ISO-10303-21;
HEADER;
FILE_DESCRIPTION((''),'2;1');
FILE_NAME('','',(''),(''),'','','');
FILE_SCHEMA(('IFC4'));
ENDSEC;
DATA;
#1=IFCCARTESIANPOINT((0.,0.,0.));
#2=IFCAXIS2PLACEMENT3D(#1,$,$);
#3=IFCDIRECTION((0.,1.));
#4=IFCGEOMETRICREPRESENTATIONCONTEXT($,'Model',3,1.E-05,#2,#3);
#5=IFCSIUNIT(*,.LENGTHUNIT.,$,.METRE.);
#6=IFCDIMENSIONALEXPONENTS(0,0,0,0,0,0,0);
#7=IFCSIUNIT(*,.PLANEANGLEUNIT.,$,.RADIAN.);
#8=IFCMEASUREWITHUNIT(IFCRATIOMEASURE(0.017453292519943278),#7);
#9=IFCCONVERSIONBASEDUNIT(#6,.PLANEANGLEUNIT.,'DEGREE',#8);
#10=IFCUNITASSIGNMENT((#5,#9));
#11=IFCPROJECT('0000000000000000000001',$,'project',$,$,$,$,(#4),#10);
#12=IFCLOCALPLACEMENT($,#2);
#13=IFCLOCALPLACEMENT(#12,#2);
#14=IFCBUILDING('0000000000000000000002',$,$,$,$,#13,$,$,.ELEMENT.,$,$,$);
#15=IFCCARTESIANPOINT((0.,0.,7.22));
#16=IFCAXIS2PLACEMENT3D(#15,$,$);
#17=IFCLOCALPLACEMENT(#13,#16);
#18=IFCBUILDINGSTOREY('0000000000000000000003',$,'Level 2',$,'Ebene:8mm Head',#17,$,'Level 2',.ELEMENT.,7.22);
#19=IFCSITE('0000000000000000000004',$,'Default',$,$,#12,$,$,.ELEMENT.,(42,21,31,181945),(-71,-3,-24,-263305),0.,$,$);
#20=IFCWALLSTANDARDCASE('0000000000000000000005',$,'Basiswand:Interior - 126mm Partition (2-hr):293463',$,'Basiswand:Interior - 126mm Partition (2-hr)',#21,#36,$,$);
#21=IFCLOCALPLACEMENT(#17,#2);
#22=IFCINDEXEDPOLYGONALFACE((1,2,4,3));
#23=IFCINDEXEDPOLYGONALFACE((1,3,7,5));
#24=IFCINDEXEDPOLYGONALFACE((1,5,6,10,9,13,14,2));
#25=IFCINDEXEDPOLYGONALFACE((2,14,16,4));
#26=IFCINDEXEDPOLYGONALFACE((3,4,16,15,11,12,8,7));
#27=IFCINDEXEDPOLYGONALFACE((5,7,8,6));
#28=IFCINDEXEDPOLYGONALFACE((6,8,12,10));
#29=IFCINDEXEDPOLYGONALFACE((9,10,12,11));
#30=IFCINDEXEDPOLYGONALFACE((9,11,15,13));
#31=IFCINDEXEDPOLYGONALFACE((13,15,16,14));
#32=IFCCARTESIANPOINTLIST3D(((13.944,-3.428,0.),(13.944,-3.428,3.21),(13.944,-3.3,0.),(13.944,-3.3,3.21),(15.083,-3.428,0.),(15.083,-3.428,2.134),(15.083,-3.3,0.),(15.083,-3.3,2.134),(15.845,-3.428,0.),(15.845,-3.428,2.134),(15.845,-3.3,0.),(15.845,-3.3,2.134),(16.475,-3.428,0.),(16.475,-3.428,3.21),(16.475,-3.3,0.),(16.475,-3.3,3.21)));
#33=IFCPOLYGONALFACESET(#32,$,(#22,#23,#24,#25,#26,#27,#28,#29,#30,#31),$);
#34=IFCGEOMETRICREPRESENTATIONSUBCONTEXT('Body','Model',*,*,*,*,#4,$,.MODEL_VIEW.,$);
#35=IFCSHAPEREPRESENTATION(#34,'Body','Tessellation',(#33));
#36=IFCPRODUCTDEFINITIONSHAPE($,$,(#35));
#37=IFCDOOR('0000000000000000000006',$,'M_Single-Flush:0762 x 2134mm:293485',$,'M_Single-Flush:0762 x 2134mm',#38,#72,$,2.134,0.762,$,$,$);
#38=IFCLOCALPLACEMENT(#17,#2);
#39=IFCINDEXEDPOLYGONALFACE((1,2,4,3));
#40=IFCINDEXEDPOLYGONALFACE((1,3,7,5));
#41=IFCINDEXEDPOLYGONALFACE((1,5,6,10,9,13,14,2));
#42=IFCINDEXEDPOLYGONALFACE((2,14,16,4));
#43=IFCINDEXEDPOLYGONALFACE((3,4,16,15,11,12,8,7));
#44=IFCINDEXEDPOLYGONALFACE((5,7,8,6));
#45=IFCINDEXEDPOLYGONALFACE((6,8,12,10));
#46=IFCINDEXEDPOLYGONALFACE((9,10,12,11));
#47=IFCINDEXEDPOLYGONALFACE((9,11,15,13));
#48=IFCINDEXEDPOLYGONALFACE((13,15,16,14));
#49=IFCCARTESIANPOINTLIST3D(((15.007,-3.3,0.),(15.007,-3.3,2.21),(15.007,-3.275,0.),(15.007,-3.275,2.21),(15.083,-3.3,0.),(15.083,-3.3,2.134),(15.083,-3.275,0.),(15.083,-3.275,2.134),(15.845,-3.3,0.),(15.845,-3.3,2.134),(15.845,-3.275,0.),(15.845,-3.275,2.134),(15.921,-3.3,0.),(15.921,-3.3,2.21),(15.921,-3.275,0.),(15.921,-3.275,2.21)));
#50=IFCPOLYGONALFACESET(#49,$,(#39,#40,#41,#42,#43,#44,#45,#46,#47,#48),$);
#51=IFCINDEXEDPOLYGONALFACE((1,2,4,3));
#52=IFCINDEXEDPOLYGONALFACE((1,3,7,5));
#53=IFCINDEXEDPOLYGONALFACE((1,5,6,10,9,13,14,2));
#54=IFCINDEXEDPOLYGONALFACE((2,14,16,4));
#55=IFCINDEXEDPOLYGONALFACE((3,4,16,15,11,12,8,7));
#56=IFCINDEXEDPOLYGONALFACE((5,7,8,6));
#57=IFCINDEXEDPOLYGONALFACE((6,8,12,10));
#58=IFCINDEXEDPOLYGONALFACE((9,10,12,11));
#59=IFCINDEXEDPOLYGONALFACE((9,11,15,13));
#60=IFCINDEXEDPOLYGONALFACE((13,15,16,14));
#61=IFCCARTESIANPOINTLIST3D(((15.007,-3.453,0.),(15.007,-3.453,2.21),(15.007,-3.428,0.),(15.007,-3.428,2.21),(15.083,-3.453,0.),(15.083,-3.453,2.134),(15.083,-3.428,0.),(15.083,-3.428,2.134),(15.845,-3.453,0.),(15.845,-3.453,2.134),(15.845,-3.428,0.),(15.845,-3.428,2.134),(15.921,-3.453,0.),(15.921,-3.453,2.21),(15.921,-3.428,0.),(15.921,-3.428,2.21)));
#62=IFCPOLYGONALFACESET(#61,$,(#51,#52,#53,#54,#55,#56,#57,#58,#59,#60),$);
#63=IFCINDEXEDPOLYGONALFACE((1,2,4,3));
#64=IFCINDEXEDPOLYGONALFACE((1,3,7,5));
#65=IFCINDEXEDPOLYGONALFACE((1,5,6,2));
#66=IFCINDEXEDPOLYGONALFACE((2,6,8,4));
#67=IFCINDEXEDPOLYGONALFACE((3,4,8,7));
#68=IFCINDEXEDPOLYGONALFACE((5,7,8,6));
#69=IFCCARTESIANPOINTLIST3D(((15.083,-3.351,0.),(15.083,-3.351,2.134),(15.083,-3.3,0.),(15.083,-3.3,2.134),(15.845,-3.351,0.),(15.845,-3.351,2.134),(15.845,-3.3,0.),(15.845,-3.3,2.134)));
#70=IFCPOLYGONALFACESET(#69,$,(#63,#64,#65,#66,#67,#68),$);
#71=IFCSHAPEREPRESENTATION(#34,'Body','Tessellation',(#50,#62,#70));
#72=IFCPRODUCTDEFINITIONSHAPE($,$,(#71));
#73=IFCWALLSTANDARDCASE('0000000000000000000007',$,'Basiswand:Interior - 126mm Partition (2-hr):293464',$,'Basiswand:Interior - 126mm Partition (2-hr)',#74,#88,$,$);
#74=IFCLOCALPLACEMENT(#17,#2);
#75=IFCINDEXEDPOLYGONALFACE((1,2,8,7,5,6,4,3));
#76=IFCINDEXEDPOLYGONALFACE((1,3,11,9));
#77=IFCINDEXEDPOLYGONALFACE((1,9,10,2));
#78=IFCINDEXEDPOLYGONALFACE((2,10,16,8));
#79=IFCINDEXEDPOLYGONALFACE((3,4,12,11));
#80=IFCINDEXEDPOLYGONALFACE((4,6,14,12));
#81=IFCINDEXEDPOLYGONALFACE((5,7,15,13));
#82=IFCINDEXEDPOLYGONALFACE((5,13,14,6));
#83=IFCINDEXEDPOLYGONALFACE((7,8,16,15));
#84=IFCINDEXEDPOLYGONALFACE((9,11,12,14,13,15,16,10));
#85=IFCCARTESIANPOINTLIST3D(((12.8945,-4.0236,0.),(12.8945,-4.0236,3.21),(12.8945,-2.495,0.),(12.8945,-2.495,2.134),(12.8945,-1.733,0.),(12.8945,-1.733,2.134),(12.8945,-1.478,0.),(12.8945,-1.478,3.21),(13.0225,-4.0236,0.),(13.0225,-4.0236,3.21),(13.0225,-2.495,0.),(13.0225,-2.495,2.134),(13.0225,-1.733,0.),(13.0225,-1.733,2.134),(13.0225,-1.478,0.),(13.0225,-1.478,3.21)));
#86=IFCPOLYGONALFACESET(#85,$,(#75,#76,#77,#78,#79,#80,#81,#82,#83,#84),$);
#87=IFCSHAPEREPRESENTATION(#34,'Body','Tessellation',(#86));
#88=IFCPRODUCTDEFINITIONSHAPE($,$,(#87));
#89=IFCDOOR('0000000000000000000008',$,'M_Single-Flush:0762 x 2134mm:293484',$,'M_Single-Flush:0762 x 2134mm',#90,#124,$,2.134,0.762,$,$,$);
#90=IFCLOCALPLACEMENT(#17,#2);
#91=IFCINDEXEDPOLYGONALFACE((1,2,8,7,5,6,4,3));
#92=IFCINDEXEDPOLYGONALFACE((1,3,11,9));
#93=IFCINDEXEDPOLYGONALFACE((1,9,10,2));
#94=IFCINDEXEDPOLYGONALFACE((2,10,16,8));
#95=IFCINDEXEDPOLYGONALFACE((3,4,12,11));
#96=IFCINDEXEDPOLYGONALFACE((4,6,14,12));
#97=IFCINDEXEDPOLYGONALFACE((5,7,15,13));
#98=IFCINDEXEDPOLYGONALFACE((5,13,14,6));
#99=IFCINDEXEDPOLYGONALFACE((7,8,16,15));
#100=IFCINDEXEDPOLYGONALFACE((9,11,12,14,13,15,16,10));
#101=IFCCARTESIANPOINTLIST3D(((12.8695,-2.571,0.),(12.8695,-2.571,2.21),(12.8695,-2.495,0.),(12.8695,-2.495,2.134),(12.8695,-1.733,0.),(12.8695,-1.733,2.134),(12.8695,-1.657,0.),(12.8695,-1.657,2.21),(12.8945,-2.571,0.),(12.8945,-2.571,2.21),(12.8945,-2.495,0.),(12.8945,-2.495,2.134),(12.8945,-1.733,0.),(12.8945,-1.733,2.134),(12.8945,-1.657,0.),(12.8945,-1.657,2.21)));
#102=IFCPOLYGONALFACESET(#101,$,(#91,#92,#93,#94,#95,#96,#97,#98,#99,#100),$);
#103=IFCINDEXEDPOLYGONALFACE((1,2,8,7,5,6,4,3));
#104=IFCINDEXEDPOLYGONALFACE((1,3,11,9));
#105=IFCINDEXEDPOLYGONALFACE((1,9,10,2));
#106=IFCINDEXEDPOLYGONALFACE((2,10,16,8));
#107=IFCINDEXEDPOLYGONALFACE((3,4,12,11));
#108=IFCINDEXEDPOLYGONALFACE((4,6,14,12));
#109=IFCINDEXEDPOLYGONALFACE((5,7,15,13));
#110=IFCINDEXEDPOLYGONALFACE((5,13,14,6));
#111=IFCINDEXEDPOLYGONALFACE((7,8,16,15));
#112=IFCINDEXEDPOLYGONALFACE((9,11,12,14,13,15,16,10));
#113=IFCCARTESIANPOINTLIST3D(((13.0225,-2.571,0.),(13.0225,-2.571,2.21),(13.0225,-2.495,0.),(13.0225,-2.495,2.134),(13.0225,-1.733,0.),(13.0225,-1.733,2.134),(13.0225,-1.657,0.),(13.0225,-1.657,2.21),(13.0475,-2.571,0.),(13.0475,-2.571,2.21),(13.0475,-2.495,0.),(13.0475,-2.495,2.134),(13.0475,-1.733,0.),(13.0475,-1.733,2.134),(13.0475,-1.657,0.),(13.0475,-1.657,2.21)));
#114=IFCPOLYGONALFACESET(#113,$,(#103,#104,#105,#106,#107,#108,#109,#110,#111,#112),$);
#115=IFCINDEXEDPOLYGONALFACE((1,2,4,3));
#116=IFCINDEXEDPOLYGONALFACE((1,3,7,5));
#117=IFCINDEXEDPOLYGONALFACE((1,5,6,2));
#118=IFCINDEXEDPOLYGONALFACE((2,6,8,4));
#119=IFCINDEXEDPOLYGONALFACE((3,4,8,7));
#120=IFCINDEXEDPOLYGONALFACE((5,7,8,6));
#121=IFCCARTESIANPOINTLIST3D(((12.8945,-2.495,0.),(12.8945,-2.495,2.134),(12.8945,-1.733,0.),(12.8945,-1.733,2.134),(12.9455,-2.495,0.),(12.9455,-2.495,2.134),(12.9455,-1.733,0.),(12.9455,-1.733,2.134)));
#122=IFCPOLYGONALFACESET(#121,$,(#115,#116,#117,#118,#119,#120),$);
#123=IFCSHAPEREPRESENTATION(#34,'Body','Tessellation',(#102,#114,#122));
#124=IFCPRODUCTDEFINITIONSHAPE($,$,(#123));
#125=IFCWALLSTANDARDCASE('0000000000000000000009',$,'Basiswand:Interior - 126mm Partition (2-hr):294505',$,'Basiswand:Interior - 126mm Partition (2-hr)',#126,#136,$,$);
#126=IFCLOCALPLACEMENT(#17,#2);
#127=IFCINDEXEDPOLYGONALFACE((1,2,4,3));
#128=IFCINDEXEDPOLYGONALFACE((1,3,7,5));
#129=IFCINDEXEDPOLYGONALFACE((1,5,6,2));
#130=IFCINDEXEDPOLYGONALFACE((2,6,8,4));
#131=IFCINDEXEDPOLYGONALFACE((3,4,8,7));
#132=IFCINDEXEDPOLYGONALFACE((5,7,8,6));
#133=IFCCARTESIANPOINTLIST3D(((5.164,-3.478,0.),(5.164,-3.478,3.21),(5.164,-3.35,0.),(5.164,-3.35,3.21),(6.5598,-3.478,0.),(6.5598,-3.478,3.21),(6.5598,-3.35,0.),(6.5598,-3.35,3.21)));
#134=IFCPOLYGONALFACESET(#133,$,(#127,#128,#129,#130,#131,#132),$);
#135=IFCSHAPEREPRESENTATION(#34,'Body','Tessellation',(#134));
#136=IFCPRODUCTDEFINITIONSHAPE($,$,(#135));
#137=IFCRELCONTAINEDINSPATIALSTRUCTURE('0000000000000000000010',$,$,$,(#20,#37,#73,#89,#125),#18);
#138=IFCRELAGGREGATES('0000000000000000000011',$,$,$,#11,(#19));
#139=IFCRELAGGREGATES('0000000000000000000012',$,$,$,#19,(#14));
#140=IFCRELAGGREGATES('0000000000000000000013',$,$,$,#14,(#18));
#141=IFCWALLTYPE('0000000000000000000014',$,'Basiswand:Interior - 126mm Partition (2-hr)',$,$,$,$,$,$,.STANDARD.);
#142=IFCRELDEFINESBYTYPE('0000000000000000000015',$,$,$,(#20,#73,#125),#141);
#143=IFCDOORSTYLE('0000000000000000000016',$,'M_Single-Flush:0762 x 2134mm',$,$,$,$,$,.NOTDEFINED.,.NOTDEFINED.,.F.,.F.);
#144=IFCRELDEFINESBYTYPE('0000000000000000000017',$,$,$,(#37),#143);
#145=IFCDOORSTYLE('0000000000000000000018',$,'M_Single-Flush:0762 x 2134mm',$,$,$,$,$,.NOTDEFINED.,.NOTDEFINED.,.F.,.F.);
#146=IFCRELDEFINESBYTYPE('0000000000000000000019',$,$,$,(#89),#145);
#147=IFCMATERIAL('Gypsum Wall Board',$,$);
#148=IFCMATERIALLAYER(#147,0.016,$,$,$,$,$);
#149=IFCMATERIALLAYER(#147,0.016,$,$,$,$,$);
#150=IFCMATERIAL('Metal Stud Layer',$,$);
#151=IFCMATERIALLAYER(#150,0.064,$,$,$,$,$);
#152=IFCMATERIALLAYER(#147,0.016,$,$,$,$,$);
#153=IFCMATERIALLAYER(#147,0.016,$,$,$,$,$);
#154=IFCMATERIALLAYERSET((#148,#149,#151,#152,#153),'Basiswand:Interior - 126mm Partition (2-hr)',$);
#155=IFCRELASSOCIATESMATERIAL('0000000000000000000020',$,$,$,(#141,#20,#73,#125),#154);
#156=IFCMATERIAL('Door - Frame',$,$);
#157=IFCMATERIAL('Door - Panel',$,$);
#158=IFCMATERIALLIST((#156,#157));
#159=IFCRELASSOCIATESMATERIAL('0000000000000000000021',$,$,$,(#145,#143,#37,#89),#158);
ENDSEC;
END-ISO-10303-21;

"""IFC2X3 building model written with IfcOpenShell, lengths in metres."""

from ifc_helpers import new_model, entity, si_unit, converted_unit, direction, frame, frame_2d, origin, place, context, subcontext, project, spatial, polyline, rectangle, outline, extrude, clip, bounded_halfspace, source, transform, mapped, material, material_list, layer, layer_set, layer_usage, type_object, type_shapes, element, fill, save


model = new_model("IFC2X3")

# Units and contexts
model_context = context("Model", 3, precision=1e-05, world=origin(), true_north=direction((0.0, 1.0)))
body_context = subcontext(model_context, "Body", "Model", "MODEL_VIEW")
ifc_project = project(units=[si_unit("LENGTHUNIT", "METRE"), converted_unit("PLANEANGLEUNIT", "DEGREE", entity("IfcRatioMeasure", 0.017453292519943278), si_unit("PLANEANGLEUNIT", "RADIAN"), dimensions=[0, 0, 0, 0, 0, 0, 0])], contexts=[model_context])

# Site, building, storey
site_placement = place(None, origin())
site = spatial("IfcSite", under=ifc_project, at=site_placement, Name="Default", CompositionType="ELEMENT", RefLatitude=(42, 21, 31, 181945), RefLongitude=(-71, -3, -24, -263305), RefElevation=0.0)
building_placement = place(site_placement, origin())
building = spatial("IfcBuilding", under=site, at=building_placement, CompositionType="ELEMENT")
storey_placement = place(building_placement, frame((0.0, 0.0, 7.22)))
storey = spatial("IfcBuildingStorey", under=building, at=storey_placement, Name="Level 2", ObjectType="Ebene:8mm Head", LongName="Level 2", CompositionType="ELEMENT", Elevation=7.22)

# Shared definitions
ifc_material_1 = material(Name="Door - Frame")
ifc_material_2 = material(Name="Door - Panel")
ifc_material_list = material_list([ifc_material_1, ifc_material_2])

# Shared definitions
ifc_material_3 = material(Name="Gypsum Wall Board")
ifc_layer_1 = layer(ifc_material_3, 0.016)
ifc_layer_2 = layer(ifc_material_3, 0.016)
ifc_material_4 = material(Name="Metal Stud Layer")
ifc_layer_3 = layer(ifc_material_4, 0.064)
ifc_layer_4 = layer(ifc_material_3, 0.016)
ifc_layer_5 = layer(ifc_material_3, 0.016)
ifc_layer_set_1 = layer_set([ifc_layer_1, ifc_layer_2, ifc_layer_3, ifc_layer_4, ifc_layer_5], Name="Basiswand:Interior - 126mm Partition (2-hr)")
ifc_layer_usage_1 = layer_usage(ifc_layer_set_1, "AXIS2", "NEGATIVE", 0.064)
wall_type_1 = type_object("IfcWallType", Name="Basiswand:Interior - 126mm Partition (2-hr)", PredefinedType="STANDARD", material=ifc_layer_set_1)

# Walls, openings, doors
door_style_1 = type_object("IfcDoorStyle", Name="M_Single-Flush:0762 x 2134mm", ConstructionType="NOTDEFINED", OperationType="NOTDEFINED", ParameterTakesPrecedence=False, Sizeable=False, material=ifc_material_list)
shared_shape_1 = source(origin(), body_context, "Body", "SweptSolid", [
    extrude(outline(polyline([(-0.457, -1.124), (0.457, -1.124), (0.457, 1.086), (0.381, 1.086), (0.381, -1.048), (-0.381, -1.048), (-0.381, 1.086), (-0.457, 1.086), (-0.457, -1.124)])), frame((0.381, 0.128, 1.086), z_axis=(0.0, 1.0, 0.0), x_axis=(1.0, 0.0, 0.0)), (0.0, 0.0, 1.0), 0.025),
    extrude(outline(polyline([(-1.124, -0.457), (1.086, -0.457), (1.086, -0.381), (-1.048, -0.381), (-1.048, 0.381), (1.086, 0.381), (1.086, 0.457), (-1.124, 0.457), (-1.124, -0.457)])), frame((0.381, -0.025, 1.086), z_axis=(0.0, 1.0, 0.0), x_axis=(0.0, 0.0, -1.0)), (0.0, 0.0, 1.0), 0.025),
    extrude(rectangle(XDim=0.051, YDim=0.762, at=frame_2d((0.0, 0.0), x_axis=(1.0, 0.0))), frame((0.381, 0.1025, 0.0), z_axis=(0.0, 0.0, 1.0), x_axis=(0.0, 1.0, 0.0)), (0.0, 0.0, 1.0), 2.134),
])
type_shapes(door_style_1, [shared_shape_1])
door_style_2 = type_object("IfcDoorStyle", Name="M_Single-Flush:0762 x 2134mm", ConstructionType="NOTDEFINED", OperationType="NOTDEFINED", ParameterTakesPrecedence=False, Sizeable=False, material=ifc_material_list)
shared_shape_2 = source(origin(), body_context, "Body", "SweptSolid", [
    extrude(outline(polyline([(-0.457, -1.124), (0.457, -1.124), (0.457, 1.086), (0.381, 1.086), (0.381, -1.048), (-0.381, -1.048), (-0.381, 1.086), (-0.457, 1.086), (-0.457, -1.124)])), frame((0.381, 0.153, 1.086), z_axis=(0.0, -1.0, 0.0), x_axis=(-1.0, 0.0, 0.0)), (0.0, 0.0, 1.0), 0.025),
    extrude(outline(polyline([(-1.124, -0.457), (1.086, -0.457), (1.086, -0.381), (-1.048, -0.381), (-1.048, 0.381), (1.086, 0.381), (1.086, 0.457), (-1.124, 0.457), (-1.124, -0.457)])), frame((0.381, 0.0, 1.086), z_axis=(0.0, -1.0, 0.0), x_axis=(0.0, 0.0, -1.0)), (0.0, 0.0, 1.0), 0.025),
    extrude(rectangle(XDim=0.762, YDim=0.051, at=frame_2d((0.0, 0.0), x_axis=(1.0, 0.0))), frame((0.381, 0.1025, 0.0)), (0.0, 0.0, 1.0), 2.134),
])
type_shapes(door_style_2, [shared_shape_2])
wall_1_placement = place(storey_placement, frame((13.944, -3.364, 0.0)))
wall_1 = element("IfcWallStandardCase", 1, at=wall_1_placement, inside=storey, type_object=wall_type_1, material=ifc_layer_usage_1, Name="Basiswand:Interior - 126mm Partition (2-hr):293463", ObjectType="Basiswand:Interior - 126mm Partition (2-hr)", context=body_context, shape_type="Clipping", body=[
    clip(extrude(rectangle(XDim=2.531, YDim=0.128, at=frame_2d((1.2655, 0.0), x_axis=(-1.0, 0.0))), origin(), (0.0, 0.0, 1.0), 3.21), bounded_halfspace(frame((0.0, -0.064, 3.21), z_axis=(0.0, 0.0, -1.0), x_axis=(0.0, 1.0, 0.0)), True, frame((0.0, -0.064, 3.21)), polyline([(0.0, 0.0), (2.531, 0.0), (2.531, 0.128), (0.784, 0.128), (0.656, 0.128), (0.0, 0.128), (0.0, 0.0)]))),
])
opening_1_placement = place(wall_1_placement, frame((1.139, -0.064, 0.0)))
opening_1 = element("IfcOpeningElement", 2, at=opening_1_placement, cuts=wall_1, ObjectType="Opening", context=body_context, shape_type="SweptSolid", body=[
    extrude(rectangle(XDim=0.762, YDim=2.134, at=frame_2d((1.067, 0.381), x_axis=(0.0, -1.0))), frame((0.0, 0.0, 0.0), z_axis=(0.0, 1.0, 0.0), x_axis=(0.0, 0.0, 1.0)), (0.0, 0.0, 1.0), 0.128),
])
door_1_placement = place(opening_1_placement, origin())
door_1 = element("IfcDoor", 3, at=door_1_placement, inside=storey, type_object=door_style_2, material=ifc_material_list, Name="M_Single-Flush:0762 x 2134mm:293485", ObjectType="M_Single-Flush:0762 x 2134mm", OverallHeight=2.134, OverallWidth=0.762, context=body_context, shape_type="MappedRepresentation", body=[
    mapped(shared_shape_2, transform((0.0, 0.0, 0.0), scale=1.0)),
])
fill(opening_1, door_1)
wall_2_placement = place(storey_placement, frame((12.9585, -4.0236, 0.0), z_axis=(0.0, 0.0, 1.0), x_axis=(0.0, 1.0, 0.0)))
wall_2 = element("IfcWallStandardCase", 4, at=wall_2_placement, inside=storey, type_object=wall_type_1, material=ifc_layer_usage_1, Name="Basiswand:Interior - 126mm Partition (2-hr):293464", ObjectType="Basiswand:Interior - 126mm Partition (2-hr)", context=body_context, shape_type="Clipping", body=[
    clip(extrude(rectangle(XDim=2.5456, YDim=0.128, at=frame_2d((1.2728, 0.0), x_axis=(-1.0, 0.0))), origin(), (0.0, 0.0, 1.0), 3.21), bounded_halfspace(frame((0.0, -0.064, 3.21), z_axis=(0.0, 0.0, -1.0), x_axis=(1.0, 0.0, 0.0)), True, frame((0.0, -0.064, 3.21)), polyline([(0.0, 0.0), (2.5456, 0.0), (2.5456, 0.128), (0.6736, 0.128), (0.5456, 0.128), (0.0, 0.128), (0.0, 0.0)]))),
])
opening_2_placement = place(wall_2_placement, frame((1.5286, -0.064, 0.0)))
opening_2 = element("IfcOpeningElement", 5, at=opening_2_placement, cuts=wall_2, ObjectType="Opening", context=body_context, shape_type="SweptSolid", body=[
    extrude(rectangle(XDim=0.762, YDim=2.134, at=frame_2d((1.067, 0.381), x_axis=(0.0, 1.0))), frame((0.0, 0.0, 0.0), z_axis=(0.0, 1.0, 0.0), x_axis=(0.0, 0.0, 1.0)), (0.0, 0.0, 1.0), 0.128),
])
door_2_placement = place(opening_2_placement, origin())
door_2 = element("IfcDoor", 6, at=door_2_placement, inside=storey, type_object=door_style_1, material=ifc_material_list, Name="M_Single-Flush:0762 x 2134mm:293484", ObjectType="M_Single-Flush:0762 x 2134mm", OverallHeight=2.134, OverallWidth=0.762, context=body_context, shape_type="MappedRepresentation", body=[
    mapped(shared_shape_1, transform((0.0, 0.0, 0.0), scale=1.0)),
])
fill(opening_2, door_2)

# Wall
ifc_layer_usage_2 = layer_usage(ifc_layer_set_1, "AXIS2", "POSITIVE", -0.064)
wall_3_placement = place(storey_placement, frame((6.5598, -3.414, 0.0), z_axis=(0.0, 0.0, 1.0), x_axis=(-1.0, 0.0, 0.0)))
element("IfcWallStandardCase", 7, at=wall_3_placement, inside=storey, type_object=wall_type_1, material=ifc_layer_usage_2, Name="Basiswand:Interior - 126mm Partition (2-hr):294505", ObjectType="Basiswand:Interior - 126mm Partition (2-hr)", context=body_context, shape_type="Clipping", body=[
    clip(extrude(rectangle(XDim=1.3958, YDim=0.128, at=frame_2d((0.6979, 0.0), x_axis=(-1.0, 0.0))), origin(), (0.0, 0.0, 1.0), 3.21), bounded_halfspace(frame((0.0, -0.064, 3.21), z_axis=(0.0, 0.0, -1.0), x_axis=(0.0, -1.0, 0.0)), True, frame((0.0, -0.064, 3.21)), polyline([(0.0, 0.0), (0.1958, 0.0), (0.3238, 0.0), (1.3958, 0.0), (1.3958, 0.128), (0.0, 0.128), (0.0, 0.0)]))),
])

save(model, "model.ifc")
